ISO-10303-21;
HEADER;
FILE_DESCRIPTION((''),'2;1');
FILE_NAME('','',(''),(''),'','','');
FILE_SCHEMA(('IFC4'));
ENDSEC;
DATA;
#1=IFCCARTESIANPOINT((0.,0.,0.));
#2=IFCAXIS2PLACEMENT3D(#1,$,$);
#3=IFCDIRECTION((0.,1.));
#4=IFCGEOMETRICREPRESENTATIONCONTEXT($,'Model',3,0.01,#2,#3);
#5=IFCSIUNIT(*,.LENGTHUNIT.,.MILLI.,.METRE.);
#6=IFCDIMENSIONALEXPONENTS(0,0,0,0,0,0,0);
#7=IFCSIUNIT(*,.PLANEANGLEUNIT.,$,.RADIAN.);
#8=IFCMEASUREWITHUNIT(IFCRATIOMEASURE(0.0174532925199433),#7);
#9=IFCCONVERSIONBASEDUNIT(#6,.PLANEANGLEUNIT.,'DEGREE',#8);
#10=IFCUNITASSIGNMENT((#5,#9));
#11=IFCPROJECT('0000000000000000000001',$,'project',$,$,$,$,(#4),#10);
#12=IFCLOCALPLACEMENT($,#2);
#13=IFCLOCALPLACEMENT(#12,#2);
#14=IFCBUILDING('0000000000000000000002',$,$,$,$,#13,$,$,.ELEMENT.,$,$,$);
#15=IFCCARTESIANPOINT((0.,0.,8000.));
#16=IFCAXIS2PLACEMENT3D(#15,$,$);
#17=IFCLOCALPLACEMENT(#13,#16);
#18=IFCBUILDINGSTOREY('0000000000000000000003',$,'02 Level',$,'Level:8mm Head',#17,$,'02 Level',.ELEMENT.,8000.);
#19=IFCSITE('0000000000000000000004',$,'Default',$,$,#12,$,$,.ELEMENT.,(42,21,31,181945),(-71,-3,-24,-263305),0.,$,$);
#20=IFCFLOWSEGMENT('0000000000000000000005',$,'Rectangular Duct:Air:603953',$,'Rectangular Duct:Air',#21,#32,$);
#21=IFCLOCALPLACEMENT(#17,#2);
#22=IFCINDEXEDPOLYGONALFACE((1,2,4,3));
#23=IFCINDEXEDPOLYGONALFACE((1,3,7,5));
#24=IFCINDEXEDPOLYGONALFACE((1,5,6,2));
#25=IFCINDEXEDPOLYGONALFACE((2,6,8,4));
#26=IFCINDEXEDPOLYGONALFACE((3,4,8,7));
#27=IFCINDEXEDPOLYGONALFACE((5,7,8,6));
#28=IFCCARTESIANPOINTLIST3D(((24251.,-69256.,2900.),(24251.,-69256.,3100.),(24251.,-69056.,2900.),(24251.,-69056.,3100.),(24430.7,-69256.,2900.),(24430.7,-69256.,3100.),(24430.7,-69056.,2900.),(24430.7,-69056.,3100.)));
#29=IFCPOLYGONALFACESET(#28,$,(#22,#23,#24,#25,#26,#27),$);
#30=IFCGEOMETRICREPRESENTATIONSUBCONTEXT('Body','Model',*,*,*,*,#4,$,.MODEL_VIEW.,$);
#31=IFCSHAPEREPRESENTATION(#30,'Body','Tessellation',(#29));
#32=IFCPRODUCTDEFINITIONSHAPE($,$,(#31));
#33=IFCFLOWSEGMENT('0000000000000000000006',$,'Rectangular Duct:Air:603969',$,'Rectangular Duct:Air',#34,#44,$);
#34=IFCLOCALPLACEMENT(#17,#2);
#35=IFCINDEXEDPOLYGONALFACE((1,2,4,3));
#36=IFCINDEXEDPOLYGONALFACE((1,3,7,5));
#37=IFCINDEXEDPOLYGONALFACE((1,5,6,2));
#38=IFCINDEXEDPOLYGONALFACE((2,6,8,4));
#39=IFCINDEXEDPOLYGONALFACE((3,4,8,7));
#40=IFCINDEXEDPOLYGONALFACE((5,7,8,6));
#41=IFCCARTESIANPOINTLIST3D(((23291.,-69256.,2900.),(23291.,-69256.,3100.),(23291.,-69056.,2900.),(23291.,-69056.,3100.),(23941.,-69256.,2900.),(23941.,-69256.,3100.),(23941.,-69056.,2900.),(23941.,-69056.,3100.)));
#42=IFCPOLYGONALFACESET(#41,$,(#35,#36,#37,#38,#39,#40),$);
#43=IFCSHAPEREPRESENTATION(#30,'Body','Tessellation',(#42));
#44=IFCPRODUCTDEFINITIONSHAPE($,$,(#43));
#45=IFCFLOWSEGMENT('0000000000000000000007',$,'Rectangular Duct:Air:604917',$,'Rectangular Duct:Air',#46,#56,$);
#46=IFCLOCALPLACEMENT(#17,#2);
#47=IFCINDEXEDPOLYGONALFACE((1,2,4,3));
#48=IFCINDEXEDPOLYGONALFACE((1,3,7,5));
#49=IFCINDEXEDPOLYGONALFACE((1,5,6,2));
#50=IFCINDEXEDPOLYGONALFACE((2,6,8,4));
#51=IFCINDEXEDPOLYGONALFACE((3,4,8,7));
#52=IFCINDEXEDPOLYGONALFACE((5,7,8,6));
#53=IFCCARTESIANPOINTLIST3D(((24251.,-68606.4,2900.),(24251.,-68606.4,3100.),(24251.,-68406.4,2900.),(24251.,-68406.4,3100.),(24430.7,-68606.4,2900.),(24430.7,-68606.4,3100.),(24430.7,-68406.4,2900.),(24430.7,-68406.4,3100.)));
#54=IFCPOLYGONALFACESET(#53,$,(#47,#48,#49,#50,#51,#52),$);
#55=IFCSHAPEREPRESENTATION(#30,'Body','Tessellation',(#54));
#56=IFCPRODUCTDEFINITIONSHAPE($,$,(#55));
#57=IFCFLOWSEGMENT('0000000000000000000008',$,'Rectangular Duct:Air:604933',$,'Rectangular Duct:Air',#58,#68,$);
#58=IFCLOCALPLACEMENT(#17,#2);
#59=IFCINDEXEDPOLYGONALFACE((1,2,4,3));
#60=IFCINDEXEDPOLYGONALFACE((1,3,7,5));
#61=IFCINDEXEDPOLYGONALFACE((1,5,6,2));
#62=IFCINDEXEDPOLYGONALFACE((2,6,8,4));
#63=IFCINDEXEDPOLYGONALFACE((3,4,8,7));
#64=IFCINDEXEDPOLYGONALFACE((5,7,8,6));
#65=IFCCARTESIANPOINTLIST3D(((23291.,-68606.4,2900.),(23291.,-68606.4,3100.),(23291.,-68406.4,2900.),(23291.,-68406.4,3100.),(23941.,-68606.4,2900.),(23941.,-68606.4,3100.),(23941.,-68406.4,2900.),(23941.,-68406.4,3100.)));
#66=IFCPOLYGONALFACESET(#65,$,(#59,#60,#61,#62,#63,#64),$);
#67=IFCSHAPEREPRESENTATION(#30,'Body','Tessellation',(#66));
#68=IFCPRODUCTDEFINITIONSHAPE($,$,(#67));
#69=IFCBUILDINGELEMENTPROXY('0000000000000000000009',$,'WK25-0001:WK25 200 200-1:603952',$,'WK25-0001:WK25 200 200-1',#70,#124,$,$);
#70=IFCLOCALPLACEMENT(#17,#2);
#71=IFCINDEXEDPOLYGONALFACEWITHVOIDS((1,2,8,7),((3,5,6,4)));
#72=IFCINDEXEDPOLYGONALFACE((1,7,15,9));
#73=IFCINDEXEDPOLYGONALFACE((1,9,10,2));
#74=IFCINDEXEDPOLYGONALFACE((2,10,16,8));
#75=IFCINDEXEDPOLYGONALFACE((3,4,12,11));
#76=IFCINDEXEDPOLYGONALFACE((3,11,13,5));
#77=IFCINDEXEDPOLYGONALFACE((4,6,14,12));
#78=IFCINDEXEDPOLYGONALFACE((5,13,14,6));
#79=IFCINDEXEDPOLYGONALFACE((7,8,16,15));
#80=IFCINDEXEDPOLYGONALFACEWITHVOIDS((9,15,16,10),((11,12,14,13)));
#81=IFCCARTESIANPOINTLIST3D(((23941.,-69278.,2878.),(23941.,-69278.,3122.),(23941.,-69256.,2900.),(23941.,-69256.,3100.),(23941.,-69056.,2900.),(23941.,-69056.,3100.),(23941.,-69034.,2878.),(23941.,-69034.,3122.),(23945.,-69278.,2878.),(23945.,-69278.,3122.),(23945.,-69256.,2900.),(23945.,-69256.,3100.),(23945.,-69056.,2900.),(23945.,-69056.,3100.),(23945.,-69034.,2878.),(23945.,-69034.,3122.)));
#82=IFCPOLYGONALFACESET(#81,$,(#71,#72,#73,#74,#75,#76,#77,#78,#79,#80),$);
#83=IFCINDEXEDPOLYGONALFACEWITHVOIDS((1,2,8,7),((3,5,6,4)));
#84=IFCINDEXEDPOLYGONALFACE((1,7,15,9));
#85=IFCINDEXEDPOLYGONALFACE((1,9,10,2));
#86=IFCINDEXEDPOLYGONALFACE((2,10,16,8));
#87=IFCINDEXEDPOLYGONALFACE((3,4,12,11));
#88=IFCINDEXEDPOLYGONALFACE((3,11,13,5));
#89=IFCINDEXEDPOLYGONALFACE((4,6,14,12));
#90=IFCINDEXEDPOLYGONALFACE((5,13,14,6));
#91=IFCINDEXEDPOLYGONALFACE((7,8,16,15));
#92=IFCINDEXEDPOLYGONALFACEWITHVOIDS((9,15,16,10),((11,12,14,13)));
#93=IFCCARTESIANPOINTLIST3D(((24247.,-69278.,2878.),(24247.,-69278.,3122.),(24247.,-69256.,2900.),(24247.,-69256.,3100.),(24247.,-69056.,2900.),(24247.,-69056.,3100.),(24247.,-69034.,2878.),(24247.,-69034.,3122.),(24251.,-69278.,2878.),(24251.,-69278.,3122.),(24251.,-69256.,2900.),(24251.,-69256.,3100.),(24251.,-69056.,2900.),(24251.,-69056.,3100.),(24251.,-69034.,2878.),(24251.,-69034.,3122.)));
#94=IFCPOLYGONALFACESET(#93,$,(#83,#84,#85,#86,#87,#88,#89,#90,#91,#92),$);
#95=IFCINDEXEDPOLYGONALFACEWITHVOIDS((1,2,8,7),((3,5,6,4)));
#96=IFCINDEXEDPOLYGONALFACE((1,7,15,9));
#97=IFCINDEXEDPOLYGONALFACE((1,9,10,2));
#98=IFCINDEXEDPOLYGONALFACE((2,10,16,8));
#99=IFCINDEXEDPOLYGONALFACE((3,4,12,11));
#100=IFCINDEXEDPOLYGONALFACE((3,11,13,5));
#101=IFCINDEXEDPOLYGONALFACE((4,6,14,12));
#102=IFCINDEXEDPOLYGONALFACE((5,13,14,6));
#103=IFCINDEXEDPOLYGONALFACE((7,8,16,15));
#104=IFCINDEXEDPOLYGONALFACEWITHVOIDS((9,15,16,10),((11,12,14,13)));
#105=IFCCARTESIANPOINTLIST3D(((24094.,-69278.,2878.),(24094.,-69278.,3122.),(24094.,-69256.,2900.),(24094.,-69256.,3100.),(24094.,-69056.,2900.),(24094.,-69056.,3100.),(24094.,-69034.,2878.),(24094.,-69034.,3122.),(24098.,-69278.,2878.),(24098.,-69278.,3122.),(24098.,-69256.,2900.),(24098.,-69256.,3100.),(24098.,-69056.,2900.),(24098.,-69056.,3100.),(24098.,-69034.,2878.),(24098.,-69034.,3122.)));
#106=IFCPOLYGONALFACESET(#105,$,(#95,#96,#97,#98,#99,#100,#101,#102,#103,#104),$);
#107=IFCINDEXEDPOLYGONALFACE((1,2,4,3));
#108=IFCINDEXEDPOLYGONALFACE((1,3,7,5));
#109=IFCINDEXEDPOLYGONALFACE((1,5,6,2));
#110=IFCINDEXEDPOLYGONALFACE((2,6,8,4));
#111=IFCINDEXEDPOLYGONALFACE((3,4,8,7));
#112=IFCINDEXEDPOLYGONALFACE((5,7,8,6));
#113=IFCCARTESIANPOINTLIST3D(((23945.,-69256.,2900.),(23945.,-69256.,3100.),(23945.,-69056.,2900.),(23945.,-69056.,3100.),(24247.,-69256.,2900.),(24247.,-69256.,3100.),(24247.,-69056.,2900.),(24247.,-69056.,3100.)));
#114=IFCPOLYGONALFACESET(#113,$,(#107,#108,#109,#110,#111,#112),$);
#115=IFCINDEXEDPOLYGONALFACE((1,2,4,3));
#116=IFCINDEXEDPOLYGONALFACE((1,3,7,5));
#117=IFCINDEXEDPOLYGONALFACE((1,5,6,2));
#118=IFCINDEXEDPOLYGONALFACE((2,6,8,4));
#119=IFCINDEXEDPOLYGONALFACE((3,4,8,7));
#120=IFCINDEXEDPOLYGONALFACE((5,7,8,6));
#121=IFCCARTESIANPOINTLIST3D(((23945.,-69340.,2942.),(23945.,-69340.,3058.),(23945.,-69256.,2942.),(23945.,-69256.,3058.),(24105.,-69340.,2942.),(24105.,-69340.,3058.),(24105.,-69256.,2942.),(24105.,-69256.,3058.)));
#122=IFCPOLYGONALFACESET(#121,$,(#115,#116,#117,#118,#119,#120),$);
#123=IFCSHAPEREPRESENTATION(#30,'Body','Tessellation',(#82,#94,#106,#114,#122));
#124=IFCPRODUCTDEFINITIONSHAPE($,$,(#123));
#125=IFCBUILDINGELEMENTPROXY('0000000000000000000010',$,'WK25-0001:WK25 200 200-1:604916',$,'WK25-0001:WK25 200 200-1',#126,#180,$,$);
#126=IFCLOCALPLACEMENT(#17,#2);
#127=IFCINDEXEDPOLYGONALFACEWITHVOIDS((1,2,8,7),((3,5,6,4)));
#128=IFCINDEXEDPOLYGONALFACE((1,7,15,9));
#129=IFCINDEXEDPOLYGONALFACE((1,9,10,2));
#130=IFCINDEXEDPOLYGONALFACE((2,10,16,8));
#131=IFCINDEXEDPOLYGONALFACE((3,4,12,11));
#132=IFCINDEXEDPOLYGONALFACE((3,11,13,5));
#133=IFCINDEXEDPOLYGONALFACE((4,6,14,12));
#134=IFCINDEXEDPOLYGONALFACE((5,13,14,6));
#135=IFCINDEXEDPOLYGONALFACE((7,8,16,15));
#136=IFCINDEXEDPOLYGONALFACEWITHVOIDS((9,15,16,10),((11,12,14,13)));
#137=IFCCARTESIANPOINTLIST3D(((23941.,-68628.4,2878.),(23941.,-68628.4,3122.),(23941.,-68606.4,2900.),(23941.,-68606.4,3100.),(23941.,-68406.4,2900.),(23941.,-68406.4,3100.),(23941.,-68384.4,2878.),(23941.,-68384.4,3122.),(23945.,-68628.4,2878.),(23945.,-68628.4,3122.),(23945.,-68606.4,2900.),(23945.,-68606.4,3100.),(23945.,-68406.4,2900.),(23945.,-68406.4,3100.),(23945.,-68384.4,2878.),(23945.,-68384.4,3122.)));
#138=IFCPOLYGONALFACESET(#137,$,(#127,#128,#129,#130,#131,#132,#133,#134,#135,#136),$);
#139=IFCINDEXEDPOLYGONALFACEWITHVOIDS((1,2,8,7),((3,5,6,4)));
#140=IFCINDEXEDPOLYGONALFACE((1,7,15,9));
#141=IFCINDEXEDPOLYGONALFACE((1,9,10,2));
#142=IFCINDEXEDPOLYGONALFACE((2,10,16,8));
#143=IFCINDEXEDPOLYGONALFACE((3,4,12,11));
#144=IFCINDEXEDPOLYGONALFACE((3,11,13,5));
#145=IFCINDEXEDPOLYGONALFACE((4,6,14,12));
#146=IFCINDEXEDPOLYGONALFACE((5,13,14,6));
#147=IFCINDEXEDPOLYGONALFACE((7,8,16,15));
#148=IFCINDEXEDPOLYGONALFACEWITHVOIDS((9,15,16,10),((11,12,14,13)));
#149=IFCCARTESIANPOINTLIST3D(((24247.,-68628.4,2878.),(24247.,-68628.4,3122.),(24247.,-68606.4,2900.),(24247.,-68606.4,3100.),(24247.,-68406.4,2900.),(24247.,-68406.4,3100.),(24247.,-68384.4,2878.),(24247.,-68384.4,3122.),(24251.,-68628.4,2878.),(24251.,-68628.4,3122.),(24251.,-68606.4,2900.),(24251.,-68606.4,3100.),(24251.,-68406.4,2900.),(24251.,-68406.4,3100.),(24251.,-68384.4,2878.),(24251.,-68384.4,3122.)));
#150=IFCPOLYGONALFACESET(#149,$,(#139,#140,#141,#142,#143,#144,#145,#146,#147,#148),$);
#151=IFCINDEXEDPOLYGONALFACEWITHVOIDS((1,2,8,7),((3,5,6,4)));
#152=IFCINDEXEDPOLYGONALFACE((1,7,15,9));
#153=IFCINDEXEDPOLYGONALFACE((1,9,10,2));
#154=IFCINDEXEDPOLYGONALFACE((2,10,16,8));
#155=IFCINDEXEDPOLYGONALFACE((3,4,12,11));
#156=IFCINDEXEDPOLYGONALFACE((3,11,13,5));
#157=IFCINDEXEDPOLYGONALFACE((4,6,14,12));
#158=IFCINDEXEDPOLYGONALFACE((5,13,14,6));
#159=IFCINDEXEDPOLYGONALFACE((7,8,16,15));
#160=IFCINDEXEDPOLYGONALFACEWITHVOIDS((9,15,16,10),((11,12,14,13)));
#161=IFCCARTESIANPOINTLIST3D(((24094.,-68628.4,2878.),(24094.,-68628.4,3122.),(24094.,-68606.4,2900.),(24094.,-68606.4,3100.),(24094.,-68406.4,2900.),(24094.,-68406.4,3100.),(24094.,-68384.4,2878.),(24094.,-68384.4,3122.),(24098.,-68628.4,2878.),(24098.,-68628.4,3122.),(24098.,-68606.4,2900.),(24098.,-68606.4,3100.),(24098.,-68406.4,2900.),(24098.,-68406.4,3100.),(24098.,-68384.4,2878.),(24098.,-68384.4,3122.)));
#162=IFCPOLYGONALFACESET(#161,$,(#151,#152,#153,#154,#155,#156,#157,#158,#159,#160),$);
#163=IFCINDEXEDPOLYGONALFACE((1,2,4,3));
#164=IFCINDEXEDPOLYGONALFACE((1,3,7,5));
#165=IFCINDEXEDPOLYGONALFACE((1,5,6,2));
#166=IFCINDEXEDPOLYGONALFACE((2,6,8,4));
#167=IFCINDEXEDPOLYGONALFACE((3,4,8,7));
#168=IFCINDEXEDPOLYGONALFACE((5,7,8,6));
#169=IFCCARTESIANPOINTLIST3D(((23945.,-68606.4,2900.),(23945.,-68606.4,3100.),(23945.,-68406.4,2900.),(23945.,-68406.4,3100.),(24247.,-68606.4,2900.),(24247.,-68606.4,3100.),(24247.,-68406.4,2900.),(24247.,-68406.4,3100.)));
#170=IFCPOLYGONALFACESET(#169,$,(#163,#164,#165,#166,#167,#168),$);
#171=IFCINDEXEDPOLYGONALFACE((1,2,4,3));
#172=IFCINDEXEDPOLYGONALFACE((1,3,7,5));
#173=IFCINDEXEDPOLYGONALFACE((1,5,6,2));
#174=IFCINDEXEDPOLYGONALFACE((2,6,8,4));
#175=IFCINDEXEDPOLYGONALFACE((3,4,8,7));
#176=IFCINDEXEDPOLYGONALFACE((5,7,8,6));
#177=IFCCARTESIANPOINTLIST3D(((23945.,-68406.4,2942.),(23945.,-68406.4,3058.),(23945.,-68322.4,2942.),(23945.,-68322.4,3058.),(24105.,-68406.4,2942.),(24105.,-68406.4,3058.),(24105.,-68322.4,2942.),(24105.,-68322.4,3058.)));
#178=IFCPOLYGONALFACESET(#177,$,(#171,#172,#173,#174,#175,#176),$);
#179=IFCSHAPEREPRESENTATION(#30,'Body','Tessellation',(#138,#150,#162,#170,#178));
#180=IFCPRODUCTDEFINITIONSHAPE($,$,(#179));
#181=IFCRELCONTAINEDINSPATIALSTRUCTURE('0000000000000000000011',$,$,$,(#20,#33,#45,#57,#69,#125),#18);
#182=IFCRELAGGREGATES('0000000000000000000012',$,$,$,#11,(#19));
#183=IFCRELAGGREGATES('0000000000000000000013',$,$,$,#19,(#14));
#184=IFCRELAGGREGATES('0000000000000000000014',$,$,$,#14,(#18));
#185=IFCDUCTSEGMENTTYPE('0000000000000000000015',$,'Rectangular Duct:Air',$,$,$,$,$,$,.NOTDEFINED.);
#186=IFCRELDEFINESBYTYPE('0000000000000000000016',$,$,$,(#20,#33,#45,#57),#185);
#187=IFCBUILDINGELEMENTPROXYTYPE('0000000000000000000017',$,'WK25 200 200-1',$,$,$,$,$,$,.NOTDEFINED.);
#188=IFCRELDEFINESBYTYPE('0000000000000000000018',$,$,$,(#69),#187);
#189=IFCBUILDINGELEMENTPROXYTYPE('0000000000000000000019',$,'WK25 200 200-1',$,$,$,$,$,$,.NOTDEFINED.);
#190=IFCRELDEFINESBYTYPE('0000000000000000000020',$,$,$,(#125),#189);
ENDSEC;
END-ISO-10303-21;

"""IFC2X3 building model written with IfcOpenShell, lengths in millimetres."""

from ifc_helpers import new_model, entity, si_unit, converted_unit, direction, frame, frame_2d, origin, origin_2d_with_axis, place, context, subcontext, project, spatial, polyline, rectangle, outline, extrude, source, transform, mapped, type_object, type_shapes, element, save


model = new_model("IFC2X3")

# Units and contexts
model_context = context("Model", 3, precision=0.01, world=origin(), true_north=direction((0.0, 1.0)))
body_context = subcontext(model_context, "Body", "Model", "MODEL_VIEW")
ifc_project = project(units=[si_unit("LENGTHUNIT", "METRE", prefix="MILLI"), converted_unit("PLANEANGLEUNIT", "DEGREE", entity("IfcRatioMeasure", 0.0174532925199433), si_unit("PLANEANGLEUNIT", "RADIAN"), dimensions=[0, 0, 0, 0, 0, 0, 0])], contexts=[model_context])

# Site, building, storey
site_placement = place(None, origin())
site = spatial("IfcSite", under=ifc_project, at=site_placement, Name="Default", CompositionType="ELEMENT", RefLatitude=(42, 21, 31, 181945), RefLongitude=(-71, -3, -24, -263305), RefElevation=0.0)
building_placement = place(site_placement, origin())
building = spatial("IfcBuilding", under=site, at=building_placement, CompositionType="ELEMENT")
storey_placement = place(building_placement, frame((0.0, 0.0, 8000.0)))
storey = spatial("IfcBuildingStorey", under=building, at=storey_placement, Name="02 Level", ObjectType="Level:8mm Head", LongName="02 Level", CompositionType="ELEMENT", Elevation=8000.0)

# Flow segments
duct_segment_type_1 = type_object("IfcDuctSegmentType", Name="Rectangular Duct:Air", PredefinedType="NOTDEFINED")
flow_segment_1_placement = place(storey_placement, frame((24251.0, -69256.0, 2900.0)))
element("IfcFlowSegment", 1, at=flow_segment_1_placement, inside=storey, type_object=duct_segment_type_1, Name="Rectangular Duct:Air:603953", ObjectType="Rectangular Duct:Air", context=body_context, shape_type="SweptSolid", body=[
    extrude(rectangle(XDim=179.7, YDim=200.0, at=frame_2d((0.0, 0.0), x_axis=(1.0, 0.0))), frame((89.8, 100.0, 0.0)), (0.0, 0.0, 1.0), 200.0),
])
flow_segment_2_placement = place(storey_placement, frame((23291.0, -69256.0, 2900.0)))
element("IfcFlowSegment", 2, at=flow_segment_2_placement, inside=storey, type_object=duct_segment_type_1, Name="Rectangular Duct:Air:603969", ObjectType="Rectangular Duct:Air", context=body_context, shape_type="SweptSolid", body=[
    extrude(rectangle(XDim=650.0, YDim=200.0, at=frame_2d((0.0, 0.0), x_axis=(1.0, 0.0))), frame((325.0, 100.0, 0.0), z_axis=(0.0, 0.0, 1.0), x_axis=(-1.0, 0.0, 0.0)), (0.0, 0.0, 1.0), 200.0),
])
flow_segment_3_placement = place(storey_placement, frame((24251.0, -68606.4, 2900.0)))
element("IfcFlowSegment", 3, at=flow_segment_3_placement, inside=storey, type_object=duct_segment_type_1, Name="Rectangular Duct:Air:604917", ObjectType="Rectangular Duct:Air", context=body_context, shape_type="SweptSolid", body=[
    extrude(rectangle(XDim=179.7, YDim=200.0, at=frame_2d((0.0, 0.0), x_axis=(1.0, 0.0))), frame((89.8, 100.0, 0.0)), (0.0, 0.0, 1.0), 200.0),
])
flow_segment_4_placement = place(storey_placement, frame((23291.0, -68606.4, 2900.0)))
element("IfcFlowSegment", 4, at=flow_segment_4_placement, inside=storey, type_object=duct_segment_type_1, Name="Rectangular Duct:Air:604933", ObjectType="Rectangular Duct:Air", context=body_context, shape_type="SweptSolid", body=[
    extrude(rectangle(XDim=650.0, YDim=200.0, at=frame_2d((0.0, 0.0), x_axis=(1.0, 0.0))), frame((325.0, 100.0, 0.0), z_axis=(0.0, 0.0, 1.0), x_axis=(-1.0, 0.0, 0.0)), (0.0, 0.0, 1.0), 200.0),
])

# Building element proxies
building_element_proxy_type_1 = type_object("IfcBuildingElementProxyType", Name="WK25 200 200-1", PredefinedType="NOTDEFINED")
shared_shape_1 = source(origin(), body_context, "Body", "SweptSolid", [
    extrude(outline(polyline([(-122.0, -122.0), (122.0, -122.0), (122.0, 122.0), (-122.0, 122.0), (-122.0, -122.0)]), holes=[polyline([(-100.0, -100.0), (-100.0, 100.0), (100.0, 100.0), (100.0, -100.0), (-100.0, -100.0)])]), frame((151.0, 0.0, 0.0), z_axis=(1.0, 0.0, 0.0), x_axis=(0.0, 0.0, -1.0)), (0.0, 0.0, 1.0), 4.0),
    extrude(outline(polyline([(-122.0, -122.0), (122.0, -122.0), (122.0, 122.0), (-122.0, 122.0), (-122.0, -122.0)]), holes=[polyline([(-100.0, -100.0), (-100.0, 100.0), (100.0, 100.0), (100.0, -100.0), (-100.0, -100.0)])]), frame((-155.0, 0.0, 0.0), z_axis=(1.0, 0.0, 0.0), x_axis=(0.0, -1.0, 0.0)), (0.0, 0.0, 1.0), 4.0),
    extrude(outline(polyline([(-122.0, -122.0), (122.0, -122.0), (122.0, 122.0), (-122.0, 122.0), (-122.0, -122.0)]), holes=[polyline([(-100.0, -100.0), (-100.0, 100.0), (100.0, 100.0), (100.0, -100.0), (-100.0, -100.0)])]), frame((-2.0, 0.0, 0.0), z_axis=(1.0, 0.0, 0.0), x_axis=(0.0, -1.0, 0.0)), (0.0, 0.0, 1.0), 4.0),
    extrude(rectangle(XDim=302.0, YDim=200.0, at=origin_2d_with_axis()), frame((0.0, 0.0, -100.0), z_axis=(0.0, 0.0, 1.0), x_axis=(-1.0, 0.0, 0.0)), (0.0, 0.0, 1.0), 200.0),
    extrude(rectangle(XDim=84.0, YDim=160.0, at=frame_2d((0.0, 0.0), x_axis=(1.0, 0.0))), frame((71.0, -142.0, -58.0), z_axis=(0.0, 0.0, 1.0), x_axis=(0.0, -1.0, 0.0)), (0.0, 0.0, 1.0), 116.0),
])
type_shapes(building_element_proxy_type_1, [shared_shape_1])
proxy_1_placement = place(storey_placement, frame((24096.0, -69156.0, 3000.0), z_axis=(0.0, 0.0, -1.0), x_axis=(-1.0, 0.0, 0.0)))
element("IfcBuildingElementProxy", 5, at=proxy_1_placement, inside=storey, type_object=building_element_proxy_type_1, Name="WK25-0001:WK25 200 200-1:603952", ObjectType="WK25-0001:WK25 200 200-1", context=body_context, shape_type="MappedRepresentation", body=[
    mapped(shared_shape_1, transform((0.0, 0.0, 0.0), scale=1.0)),
])
building_element_proxy_type_2 = type_object("IfcBuildingElementProxyType", Name="WK25 200 200-1", PredefinedType="NOTDEFINED")
shared_shape_2 = source(origin(), body_context, "Body", "SweptSolid", [
    extrude(outline(polyline([(-122.0, -122.0), (122.0, -122.0), (122.0, 122.0), (-122.0, 122.0), (-122.0, -122.0)]), holes=[polyline([(-100.0, -100.0), (-100.0, 100.0), (100.0, 100.0), (100.0, -100.0), (-100.0, -100.0)])]), frame((151.0, 0.0, 0.0), z_axis=(1.0, 0.0, 0.0), x_axis=(0.0, -1.0, 0.0)), (0.0, 0.0, 1.0), 4.0),
    extrude(outline(polyline([(-122.0, -122.0), (122.0, -122.0), (122.0, 122.0), (-122.0, 122.0), (-122.0, -122.0)]), holes=[polyline([(-100.0, -100.0), (-100.0, 100.0), (100.0, 100.0), (100.0, -100.0), (-100.0, -100.0)])]), frame((-155.0, 0.0, 0.0), z_axis=(1.0, 0.0, 0.0), x_axis=(0.0, 0.0, -1.0)), (0.0, 0.0, 1.0), 4.0),
    extrude(outline(polyline([(-122.0, -122.0), (122.0, -122.0), (122.0, 122.0), (-122.0, 122.0), (-122.0, -122.0)]), holes=[polyline([(-100.0, -100.0), (-100.0, 100.0), (100.0, 100.0), (100.0, -100.0), (-100.0, -100.0)])]), frame((-2.0, 0.0, 0.0), z_axis=(1.0, 0.0, 0.0), x_axis=(0.0, 0.0, -1.0)), (0.0, 0.0, 1.0), 4.0),
    extrude(rectangle(XDim=200.0, YDim=302.0, at=origin_2d_with_axis()), frame((0.0, 0.0, -100.0), z_axis=(0.0, 0.0, 1.0), x_axis=(0.0, 1.0, 0.0)), (0.0, 0.0, 1.0), 200.0),
    extrude(rectangle(XDim=160.0, YDim=84.0, at=frame_2d((0.0, 0.0), x_axis=(1.0, 0.0))), frame((71.0, 142.0, -58.0)), (0.0, 0.0, 1.0), 116.0),
])
type_shapes(building_element_proxy_type_2, [shared_shape_2])
proxy_2_placement = place(storey_placement, frame((24096.0, -68506.4, 3000.0), z_axis=(0.0, 0.0, -1.0), x_axis=(-1.0, 0.0, 0.0)))
element("IfcBuildingElementProxy", 6, at=proxy_2_placement, inside=storey, type_object=building_element_proxy_type_2, Name="WK25-0001:WK25 200 200-1:604916", ObjectType="WK25-0001:WK25 200 200-1", context=body_context, shape_type="MappedRepresentation", body=[
    mapped(shared_shape_2, transform((0.0, 0.0, 0.0), scale=1.0)),
])

save(model, "model.ifc")
